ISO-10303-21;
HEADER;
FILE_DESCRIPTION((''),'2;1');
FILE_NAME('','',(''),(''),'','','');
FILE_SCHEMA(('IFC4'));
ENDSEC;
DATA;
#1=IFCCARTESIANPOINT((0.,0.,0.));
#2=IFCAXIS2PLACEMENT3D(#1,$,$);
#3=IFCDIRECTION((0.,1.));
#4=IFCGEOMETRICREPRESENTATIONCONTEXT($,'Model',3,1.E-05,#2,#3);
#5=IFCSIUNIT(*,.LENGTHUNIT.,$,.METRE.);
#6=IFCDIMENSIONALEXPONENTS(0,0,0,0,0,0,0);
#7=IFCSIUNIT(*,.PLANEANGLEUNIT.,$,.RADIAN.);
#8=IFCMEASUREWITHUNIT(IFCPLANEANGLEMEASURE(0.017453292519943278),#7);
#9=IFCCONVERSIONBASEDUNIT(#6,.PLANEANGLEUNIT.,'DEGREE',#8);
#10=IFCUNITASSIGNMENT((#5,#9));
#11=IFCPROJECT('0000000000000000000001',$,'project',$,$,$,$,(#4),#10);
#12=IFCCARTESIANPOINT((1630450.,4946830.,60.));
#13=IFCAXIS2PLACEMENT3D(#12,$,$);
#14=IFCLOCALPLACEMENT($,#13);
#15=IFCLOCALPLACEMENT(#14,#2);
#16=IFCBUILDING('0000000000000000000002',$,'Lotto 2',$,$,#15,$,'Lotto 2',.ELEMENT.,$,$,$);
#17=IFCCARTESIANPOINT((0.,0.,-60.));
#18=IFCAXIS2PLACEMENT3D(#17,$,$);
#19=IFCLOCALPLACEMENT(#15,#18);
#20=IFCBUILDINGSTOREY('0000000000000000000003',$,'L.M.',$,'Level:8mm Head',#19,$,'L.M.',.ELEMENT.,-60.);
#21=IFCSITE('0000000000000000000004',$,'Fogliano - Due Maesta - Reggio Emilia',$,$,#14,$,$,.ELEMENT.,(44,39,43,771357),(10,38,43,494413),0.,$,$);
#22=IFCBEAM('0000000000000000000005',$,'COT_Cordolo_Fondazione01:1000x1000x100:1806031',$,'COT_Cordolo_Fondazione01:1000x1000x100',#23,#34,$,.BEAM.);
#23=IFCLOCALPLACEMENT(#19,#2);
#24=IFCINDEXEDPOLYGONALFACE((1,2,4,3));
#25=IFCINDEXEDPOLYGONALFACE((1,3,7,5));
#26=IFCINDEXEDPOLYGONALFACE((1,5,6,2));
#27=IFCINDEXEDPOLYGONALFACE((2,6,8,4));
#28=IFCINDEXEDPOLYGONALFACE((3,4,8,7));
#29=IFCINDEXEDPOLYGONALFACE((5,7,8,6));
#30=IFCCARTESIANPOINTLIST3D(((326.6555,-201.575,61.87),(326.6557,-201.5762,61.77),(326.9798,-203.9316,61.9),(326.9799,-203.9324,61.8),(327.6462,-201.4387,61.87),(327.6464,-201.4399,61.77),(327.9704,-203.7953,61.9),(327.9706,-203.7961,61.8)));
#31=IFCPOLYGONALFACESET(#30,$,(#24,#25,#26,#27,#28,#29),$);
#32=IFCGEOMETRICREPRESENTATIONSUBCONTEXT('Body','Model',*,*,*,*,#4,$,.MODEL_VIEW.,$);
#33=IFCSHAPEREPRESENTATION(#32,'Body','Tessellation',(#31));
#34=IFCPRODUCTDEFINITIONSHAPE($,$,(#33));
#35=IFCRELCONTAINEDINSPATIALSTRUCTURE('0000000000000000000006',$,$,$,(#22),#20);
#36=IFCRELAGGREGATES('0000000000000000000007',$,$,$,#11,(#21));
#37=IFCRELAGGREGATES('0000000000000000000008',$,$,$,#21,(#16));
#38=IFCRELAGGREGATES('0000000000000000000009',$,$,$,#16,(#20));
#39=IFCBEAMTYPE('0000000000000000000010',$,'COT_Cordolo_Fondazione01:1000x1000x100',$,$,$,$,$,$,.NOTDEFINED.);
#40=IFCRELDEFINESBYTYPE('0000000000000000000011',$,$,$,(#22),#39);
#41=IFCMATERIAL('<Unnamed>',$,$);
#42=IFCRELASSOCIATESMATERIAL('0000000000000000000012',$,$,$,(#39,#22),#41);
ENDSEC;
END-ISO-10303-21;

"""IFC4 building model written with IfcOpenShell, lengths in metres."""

from ifc_helpers import new_model, entity, si_unit, converted_unit, direction, frame, origin, place, context, subcontext, project, spatial, indexed_curve, outline, extrude, source, transform, mapped, material, type_object, type_shapes, element, save


model = new_model("IFC4")

# Units and contexts
model_context = context("Model", 3, precision=1e-05, world=origin(), true_north=direction((0.0, 1.0)))
body_context = subcontext(model_context, "Body", "Model", "MODEL_VIEW")
ifc_project = project(units=[si_unit("LENGTHUNIT", "METRE"), converted_unit("PLANEANGLEUNIT", "DEGREE", entity("IfcPlaneAngleMeasure", 0.017453292519943278), si_unit("PLANEANGLEUNIT", "RADIAN"), dimensions=[0, 0, 0, 0, 0, 0, 0])], contexts=[model_context])

# Site, building, storey
site_placement = place(None, frame((1630450.0, 4946830.0, 60.0)))
site = spatial("IfcSite", under=ifc_project, at=site_placement, Name="Fogliano - Due Maesta - Reggio Emilia", CompositionType="ELEMENT", RefLatitude=(44, 39, 43, 771357), RefLongitude=(10, 38, 43, 494413), RefElevation=0.0)
building_placement = place(site_placement, origin())
building = spatial("IfcBuilding", under=site, at=building_placement, Name="Lotto 2", LongName="Lotto 2", CompositionType="ELEMENT")
storey_placement = place(building_placement, frame((0.0, 0.0, -60.0)))
storey = spatial("IfcBuildingStorey", under=building, at=storey_placement, Name="L.M.", ObjectType="Level:8mm Head", LongName="L.M.", CompositionType="ELEMENT", Elevation=-60.0)

# Beam
ifc_material_1 = material(Name="<Unnamed>")
beam_type_1 = type_object("IfcBeamType", Name="COT_Cordolo_Fondazione01:1000x1000x100", PredefinedType="NOTDEFINED", material=ifc_material_1)
shared_shape_1 = source(origin(), body_context, "Body", "SweptSolid", [
    extrude(outline(indexed_curve([(-1.1894, -0.05), (1.1896, -0.05), (1.1892, 0.05), (-1.1894, 0.05), (-1.1894, -0.05)], self_intersect=False)), frame((326.8177, -202.7538, 1.835), z_axis=(0.990667, 0.136302, 0.0), x_axis=(0.136292, -0.990589, 0.012586)), (0.0, 0.0, 1.0), 1.0),
])
type_shapes(beam_type_1, [shared_shape_1])
beam_1_placement = place(storey_placement, frame((0.0, 0.0, 60.0)))
element("IfcBeam", 1, at=beam_1_placement, inside=storey, type_object=beam_type_1, material=ifc_material_1, Name="COT_Cordolo_Fondazione01:1000x1000x100:1806031", ObjectType="COT_Cordolo_Fondazione01:1000x1000x100", PredefinedType="BEAM", context=body_context, shape_type="MappedRepresentation", body=[
    mapped(shared_shape_1, transform((0.0, 0.0, 0.0), scale=1.0)),
])

save(model, "model.ifc")
